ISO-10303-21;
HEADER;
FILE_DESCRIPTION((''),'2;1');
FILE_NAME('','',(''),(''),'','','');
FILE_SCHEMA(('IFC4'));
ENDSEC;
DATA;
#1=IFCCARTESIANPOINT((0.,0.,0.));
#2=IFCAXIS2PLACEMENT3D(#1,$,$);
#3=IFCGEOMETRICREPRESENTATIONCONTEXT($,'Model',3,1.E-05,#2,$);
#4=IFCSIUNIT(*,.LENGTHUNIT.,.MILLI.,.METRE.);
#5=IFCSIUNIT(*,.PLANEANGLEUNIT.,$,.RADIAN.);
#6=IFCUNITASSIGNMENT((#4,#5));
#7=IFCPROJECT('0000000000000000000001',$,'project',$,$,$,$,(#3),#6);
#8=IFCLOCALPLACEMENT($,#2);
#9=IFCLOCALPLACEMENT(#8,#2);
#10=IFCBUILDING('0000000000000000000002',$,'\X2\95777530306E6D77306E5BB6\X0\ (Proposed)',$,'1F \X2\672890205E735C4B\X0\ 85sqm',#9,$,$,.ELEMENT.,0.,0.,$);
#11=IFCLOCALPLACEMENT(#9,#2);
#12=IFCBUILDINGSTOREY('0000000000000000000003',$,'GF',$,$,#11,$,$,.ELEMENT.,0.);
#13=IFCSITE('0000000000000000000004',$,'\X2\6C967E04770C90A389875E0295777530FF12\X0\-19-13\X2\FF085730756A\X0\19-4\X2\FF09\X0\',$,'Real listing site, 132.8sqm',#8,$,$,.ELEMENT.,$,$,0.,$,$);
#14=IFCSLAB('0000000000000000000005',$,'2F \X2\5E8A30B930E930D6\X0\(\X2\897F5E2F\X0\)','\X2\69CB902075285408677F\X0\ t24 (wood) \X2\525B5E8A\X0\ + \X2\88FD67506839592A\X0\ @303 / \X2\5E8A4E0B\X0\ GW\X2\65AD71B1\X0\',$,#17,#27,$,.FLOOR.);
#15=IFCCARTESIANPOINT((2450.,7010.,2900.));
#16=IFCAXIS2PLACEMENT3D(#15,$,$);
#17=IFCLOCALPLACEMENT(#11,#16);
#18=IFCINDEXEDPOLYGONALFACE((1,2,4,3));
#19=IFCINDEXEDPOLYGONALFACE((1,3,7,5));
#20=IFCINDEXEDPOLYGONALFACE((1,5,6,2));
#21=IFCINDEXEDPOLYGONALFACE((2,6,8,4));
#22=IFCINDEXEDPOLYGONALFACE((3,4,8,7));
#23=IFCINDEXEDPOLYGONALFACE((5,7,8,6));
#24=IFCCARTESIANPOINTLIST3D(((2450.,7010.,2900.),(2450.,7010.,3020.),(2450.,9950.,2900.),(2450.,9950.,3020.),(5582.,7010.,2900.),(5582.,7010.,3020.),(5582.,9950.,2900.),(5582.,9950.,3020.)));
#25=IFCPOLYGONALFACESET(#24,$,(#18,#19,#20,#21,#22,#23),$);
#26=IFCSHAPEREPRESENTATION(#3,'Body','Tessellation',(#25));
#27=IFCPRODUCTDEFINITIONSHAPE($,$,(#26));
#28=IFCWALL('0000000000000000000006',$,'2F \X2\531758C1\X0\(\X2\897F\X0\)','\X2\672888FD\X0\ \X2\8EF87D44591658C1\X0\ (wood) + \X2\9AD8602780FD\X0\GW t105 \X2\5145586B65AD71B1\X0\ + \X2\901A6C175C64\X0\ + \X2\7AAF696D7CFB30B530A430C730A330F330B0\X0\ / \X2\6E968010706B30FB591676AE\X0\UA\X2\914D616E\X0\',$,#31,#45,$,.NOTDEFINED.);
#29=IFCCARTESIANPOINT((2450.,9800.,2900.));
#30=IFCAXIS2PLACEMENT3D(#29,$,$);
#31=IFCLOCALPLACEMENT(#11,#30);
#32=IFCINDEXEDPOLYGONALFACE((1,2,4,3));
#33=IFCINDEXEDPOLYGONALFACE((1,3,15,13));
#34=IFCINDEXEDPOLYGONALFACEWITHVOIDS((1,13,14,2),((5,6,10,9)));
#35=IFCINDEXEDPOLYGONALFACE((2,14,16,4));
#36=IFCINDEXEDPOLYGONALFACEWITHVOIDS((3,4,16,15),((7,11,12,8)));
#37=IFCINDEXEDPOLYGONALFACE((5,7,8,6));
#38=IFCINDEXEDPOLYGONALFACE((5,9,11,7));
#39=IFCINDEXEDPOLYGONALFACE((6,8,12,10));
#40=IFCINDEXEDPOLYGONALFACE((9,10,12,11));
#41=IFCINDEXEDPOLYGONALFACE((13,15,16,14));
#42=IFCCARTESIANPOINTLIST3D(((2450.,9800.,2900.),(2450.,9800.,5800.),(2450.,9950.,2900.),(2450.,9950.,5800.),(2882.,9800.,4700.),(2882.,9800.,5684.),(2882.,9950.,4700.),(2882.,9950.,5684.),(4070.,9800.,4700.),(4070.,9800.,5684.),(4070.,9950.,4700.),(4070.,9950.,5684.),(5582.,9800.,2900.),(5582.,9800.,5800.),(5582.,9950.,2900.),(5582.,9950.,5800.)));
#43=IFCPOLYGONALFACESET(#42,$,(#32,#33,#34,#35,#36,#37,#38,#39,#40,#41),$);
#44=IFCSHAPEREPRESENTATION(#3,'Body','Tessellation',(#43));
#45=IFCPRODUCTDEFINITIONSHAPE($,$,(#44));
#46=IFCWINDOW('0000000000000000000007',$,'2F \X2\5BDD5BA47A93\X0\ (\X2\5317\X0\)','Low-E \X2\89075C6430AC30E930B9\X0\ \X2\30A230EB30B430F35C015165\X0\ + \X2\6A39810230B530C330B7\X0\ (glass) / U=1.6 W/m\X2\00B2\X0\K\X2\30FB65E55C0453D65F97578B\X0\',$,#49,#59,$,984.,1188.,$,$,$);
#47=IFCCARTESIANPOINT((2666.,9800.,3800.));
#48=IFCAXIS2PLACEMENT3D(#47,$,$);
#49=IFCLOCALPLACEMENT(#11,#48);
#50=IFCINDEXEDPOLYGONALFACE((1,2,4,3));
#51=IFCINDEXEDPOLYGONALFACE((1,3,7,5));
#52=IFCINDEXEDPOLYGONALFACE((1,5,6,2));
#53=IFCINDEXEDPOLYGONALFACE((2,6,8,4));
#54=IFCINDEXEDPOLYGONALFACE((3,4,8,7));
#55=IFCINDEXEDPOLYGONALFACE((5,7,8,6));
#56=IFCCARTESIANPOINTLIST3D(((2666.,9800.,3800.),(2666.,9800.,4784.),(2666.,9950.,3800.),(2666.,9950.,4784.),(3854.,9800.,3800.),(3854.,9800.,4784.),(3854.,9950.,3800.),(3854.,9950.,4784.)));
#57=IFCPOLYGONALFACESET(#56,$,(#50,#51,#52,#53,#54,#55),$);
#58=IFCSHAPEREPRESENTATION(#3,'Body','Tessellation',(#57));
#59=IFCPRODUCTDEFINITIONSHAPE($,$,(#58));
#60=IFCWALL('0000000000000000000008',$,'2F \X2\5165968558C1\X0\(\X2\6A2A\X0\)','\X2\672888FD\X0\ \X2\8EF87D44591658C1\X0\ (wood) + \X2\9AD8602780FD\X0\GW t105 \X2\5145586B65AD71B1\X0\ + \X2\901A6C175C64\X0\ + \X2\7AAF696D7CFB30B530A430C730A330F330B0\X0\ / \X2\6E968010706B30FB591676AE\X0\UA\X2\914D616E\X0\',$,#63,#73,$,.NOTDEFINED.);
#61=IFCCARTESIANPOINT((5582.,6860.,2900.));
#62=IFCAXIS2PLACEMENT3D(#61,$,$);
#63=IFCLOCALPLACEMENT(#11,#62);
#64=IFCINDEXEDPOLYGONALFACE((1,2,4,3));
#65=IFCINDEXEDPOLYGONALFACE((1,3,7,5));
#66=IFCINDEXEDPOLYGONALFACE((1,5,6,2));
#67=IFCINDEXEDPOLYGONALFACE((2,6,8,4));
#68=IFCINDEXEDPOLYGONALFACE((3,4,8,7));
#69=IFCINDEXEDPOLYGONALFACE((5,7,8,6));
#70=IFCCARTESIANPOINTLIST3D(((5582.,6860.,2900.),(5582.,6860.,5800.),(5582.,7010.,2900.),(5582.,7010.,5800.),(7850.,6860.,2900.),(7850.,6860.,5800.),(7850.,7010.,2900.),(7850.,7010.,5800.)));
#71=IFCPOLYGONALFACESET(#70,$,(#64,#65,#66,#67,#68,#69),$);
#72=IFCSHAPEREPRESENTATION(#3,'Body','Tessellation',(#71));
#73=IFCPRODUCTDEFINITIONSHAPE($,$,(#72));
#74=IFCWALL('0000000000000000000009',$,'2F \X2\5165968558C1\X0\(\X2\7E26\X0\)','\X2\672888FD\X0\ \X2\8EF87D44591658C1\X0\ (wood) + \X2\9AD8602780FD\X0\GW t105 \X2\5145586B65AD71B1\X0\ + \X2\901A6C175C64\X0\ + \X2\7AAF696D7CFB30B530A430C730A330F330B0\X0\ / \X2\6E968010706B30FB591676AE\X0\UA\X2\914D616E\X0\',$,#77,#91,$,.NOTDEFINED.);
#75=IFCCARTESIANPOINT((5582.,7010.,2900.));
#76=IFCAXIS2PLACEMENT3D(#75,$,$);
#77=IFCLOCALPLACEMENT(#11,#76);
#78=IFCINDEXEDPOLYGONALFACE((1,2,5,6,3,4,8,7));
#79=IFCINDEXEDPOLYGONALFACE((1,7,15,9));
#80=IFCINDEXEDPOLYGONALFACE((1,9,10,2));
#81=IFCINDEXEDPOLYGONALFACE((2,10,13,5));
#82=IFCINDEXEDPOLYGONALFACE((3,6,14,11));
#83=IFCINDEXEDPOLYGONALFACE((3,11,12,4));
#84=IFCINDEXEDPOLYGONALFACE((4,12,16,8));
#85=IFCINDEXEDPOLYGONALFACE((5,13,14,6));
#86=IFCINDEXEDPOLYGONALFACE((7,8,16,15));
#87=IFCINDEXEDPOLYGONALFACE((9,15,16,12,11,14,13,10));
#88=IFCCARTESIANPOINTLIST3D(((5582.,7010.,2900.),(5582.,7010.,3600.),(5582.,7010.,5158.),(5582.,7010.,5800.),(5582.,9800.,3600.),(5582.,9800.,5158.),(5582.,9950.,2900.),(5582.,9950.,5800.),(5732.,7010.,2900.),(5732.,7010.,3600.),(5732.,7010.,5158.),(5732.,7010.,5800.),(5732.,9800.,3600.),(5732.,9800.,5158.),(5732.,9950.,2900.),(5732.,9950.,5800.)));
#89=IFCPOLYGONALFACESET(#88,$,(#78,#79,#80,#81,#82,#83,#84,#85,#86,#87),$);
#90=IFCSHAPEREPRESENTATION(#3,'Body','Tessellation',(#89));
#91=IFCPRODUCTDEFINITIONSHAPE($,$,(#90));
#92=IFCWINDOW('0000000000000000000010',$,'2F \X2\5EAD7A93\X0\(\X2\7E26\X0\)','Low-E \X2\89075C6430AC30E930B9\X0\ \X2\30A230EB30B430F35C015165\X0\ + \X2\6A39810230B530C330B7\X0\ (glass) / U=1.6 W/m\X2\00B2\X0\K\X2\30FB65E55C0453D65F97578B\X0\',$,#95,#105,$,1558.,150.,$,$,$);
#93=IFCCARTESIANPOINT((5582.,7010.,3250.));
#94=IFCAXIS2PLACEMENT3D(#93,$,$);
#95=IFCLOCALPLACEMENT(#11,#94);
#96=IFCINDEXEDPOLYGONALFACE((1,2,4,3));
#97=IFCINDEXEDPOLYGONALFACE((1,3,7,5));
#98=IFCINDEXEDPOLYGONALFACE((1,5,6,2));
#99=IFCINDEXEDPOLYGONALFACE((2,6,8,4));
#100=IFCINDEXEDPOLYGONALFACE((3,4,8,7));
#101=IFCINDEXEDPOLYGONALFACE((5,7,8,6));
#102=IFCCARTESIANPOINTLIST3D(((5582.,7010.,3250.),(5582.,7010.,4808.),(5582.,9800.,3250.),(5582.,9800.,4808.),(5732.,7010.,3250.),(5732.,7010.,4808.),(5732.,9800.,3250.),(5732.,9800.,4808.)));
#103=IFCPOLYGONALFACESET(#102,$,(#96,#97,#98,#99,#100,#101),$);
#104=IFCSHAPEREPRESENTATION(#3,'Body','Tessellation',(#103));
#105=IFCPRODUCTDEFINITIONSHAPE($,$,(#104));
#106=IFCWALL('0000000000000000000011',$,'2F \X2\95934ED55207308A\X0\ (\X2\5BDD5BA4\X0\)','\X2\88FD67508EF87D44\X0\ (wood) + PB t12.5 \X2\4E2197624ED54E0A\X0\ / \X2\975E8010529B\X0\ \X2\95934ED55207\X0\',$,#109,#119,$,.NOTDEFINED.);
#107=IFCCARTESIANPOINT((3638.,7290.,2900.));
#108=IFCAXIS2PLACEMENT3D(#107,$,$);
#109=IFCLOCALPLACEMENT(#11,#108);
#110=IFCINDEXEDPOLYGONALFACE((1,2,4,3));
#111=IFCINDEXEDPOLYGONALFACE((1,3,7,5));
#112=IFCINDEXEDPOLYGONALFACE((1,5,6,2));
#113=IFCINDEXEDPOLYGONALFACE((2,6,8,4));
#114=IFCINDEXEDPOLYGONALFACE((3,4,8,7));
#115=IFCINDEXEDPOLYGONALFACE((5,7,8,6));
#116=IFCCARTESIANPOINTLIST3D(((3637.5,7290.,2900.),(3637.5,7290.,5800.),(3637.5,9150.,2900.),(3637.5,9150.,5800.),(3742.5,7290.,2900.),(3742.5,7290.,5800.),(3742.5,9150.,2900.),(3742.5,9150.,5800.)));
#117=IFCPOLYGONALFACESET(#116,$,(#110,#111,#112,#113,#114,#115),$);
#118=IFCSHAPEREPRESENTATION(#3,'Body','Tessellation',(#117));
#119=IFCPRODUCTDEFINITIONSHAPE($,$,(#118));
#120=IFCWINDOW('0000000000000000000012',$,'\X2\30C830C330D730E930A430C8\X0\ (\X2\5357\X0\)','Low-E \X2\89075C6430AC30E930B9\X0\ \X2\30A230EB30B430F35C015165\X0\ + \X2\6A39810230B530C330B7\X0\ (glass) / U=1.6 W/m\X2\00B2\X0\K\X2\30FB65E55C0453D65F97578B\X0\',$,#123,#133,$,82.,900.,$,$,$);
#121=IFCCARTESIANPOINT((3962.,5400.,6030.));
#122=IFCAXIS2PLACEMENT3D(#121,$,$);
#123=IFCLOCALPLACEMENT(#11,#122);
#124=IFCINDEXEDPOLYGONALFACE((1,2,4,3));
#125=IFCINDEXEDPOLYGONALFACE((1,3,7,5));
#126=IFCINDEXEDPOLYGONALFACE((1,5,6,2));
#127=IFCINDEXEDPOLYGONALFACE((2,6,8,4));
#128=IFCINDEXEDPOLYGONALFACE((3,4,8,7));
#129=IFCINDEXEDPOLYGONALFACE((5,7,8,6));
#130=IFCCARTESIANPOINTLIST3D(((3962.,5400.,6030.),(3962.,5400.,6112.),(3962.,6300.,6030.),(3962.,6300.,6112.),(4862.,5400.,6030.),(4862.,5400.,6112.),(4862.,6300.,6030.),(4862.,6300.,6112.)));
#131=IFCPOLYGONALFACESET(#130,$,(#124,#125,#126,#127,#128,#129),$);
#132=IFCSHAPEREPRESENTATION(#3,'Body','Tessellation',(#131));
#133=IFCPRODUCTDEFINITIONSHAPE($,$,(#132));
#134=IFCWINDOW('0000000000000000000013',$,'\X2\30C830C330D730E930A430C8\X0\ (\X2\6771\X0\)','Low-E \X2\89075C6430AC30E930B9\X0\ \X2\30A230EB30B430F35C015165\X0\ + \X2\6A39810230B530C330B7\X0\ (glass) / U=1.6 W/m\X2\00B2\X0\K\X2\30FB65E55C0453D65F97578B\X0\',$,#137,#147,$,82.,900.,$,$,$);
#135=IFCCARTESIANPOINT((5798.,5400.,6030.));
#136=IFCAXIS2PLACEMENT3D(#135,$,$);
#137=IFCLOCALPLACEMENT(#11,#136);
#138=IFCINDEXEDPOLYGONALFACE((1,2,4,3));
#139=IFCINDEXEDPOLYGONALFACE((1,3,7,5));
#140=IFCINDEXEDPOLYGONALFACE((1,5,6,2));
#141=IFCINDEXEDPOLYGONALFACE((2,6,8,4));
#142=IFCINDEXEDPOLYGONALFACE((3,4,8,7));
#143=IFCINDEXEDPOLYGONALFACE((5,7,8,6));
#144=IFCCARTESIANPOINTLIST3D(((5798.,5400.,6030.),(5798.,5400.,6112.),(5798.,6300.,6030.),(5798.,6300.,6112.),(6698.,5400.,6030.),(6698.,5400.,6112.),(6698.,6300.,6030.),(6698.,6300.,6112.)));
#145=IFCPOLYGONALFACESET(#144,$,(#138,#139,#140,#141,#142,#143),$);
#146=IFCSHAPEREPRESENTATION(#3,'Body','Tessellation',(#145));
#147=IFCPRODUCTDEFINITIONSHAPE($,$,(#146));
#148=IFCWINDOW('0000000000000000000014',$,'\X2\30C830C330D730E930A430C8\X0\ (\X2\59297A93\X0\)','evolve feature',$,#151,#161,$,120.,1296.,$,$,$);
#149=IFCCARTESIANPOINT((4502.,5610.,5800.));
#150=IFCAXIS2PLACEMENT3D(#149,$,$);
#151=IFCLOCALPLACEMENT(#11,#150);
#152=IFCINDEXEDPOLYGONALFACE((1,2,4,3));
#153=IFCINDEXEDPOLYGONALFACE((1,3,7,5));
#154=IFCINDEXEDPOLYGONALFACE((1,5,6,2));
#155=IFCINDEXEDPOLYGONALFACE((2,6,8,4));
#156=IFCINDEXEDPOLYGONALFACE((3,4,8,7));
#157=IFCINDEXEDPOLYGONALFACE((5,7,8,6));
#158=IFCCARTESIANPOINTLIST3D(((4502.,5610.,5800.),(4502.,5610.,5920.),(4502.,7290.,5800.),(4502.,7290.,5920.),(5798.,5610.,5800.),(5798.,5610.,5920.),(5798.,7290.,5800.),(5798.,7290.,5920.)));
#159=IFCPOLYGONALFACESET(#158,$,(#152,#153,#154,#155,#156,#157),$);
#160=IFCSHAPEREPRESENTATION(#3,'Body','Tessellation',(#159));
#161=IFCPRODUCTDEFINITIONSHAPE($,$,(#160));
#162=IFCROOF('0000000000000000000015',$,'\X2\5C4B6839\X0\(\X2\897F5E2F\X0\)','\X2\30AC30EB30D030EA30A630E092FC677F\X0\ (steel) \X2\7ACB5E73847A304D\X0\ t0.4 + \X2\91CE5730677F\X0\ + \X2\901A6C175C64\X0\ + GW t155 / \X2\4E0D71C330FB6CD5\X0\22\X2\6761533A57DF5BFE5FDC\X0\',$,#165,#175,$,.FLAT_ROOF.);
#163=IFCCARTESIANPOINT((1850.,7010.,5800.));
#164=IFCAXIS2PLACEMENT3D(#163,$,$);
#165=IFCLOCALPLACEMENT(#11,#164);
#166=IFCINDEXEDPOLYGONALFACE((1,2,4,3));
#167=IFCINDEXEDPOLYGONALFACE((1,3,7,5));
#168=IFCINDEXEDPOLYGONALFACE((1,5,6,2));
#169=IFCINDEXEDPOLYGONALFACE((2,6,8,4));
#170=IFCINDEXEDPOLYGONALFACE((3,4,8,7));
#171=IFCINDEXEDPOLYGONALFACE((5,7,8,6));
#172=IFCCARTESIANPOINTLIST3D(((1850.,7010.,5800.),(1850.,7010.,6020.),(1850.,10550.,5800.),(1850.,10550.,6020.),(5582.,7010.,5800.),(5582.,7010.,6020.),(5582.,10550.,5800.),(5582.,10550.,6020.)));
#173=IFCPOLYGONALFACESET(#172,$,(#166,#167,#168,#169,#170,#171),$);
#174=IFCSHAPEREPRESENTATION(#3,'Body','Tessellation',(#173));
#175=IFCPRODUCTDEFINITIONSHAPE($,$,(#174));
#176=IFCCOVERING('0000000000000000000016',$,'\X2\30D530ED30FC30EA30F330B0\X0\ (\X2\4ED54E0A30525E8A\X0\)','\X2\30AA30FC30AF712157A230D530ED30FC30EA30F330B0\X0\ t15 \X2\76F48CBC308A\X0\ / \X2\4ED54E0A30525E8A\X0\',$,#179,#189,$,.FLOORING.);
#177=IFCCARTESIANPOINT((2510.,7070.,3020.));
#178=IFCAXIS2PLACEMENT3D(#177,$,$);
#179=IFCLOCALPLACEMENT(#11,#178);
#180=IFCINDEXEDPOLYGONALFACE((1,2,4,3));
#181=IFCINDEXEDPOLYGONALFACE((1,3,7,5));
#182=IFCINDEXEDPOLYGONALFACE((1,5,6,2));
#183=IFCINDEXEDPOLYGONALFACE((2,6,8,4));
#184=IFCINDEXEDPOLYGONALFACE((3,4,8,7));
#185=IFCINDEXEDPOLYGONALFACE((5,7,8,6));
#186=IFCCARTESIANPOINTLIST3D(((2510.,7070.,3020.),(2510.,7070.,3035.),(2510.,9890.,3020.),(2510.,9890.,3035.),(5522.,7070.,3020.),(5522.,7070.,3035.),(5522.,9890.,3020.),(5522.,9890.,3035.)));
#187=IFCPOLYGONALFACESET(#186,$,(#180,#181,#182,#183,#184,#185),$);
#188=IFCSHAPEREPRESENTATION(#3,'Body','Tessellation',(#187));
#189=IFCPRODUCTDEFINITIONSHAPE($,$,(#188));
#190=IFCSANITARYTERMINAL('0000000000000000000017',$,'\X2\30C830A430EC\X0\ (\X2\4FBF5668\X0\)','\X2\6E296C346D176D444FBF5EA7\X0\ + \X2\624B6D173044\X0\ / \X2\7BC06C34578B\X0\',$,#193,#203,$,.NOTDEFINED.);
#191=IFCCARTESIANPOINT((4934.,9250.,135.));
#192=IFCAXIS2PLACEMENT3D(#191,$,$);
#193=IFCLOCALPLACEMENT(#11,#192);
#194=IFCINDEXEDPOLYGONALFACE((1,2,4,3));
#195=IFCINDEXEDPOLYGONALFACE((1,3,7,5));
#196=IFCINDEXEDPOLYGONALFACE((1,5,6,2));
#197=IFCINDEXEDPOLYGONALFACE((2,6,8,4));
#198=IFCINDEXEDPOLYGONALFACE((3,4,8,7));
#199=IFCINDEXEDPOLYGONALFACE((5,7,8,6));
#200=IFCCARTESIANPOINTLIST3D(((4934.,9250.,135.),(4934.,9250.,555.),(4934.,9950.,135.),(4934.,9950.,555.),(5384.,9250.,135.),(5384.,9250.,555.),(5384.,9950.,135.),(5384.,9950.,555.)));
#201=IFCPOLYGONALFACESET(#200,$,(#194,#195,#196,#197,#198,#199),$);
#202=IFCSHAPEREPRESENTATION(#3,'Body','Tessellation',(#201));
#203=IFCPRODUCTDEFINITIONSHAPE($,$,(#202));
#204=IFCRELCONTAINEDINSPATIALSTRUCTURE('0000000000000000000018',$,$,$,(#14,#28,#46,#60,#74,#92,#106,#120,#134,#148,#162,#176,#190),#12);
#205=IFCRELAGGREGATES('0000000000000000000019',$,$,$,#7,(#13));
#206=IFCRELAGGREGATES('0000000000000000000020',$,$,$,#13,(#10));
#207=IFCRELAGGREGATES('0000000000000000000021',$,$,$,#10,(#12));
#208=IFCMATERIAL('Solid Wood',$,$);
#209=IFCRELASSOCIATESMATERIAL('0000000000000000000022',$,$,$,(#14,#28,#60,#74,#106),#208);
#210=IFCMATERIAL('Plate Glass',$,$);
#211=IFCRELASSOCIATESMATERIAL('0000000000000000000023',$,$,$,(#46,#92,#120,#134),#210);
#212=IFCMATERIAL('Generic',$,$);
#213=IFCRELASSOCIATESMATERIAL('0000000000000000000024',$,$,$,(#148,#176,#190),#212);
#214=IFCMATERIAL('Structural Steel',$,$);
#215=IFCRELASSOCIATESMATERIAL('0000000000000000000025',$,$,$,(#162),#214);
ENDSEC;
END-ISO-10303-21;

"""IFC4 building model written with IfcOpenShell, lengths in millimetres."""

from ifc_helpers import new_model, si_unit, frame, frame_2d, origin, place, context, project, spatial, rectangle, extrude, material, element, fill, save


model = new_model("IFC4")

# Units and contexts
model_context = context("Model", 3, precision=1e-05, world=origin())
ifc_project = project(units=[si_unit("LENGTHUNIT", "METRE", prefix="MILLI"), si_unit("PLANEANGLEUNIT", "RADIAN")], contexts=[model_context])

# Site, building, storey
site_placement = place(None, origin())
site = spatial("IfcSite", under=ifc_project, at=site_placement, Name="沖縄県那覇市長田２-19-13（地番19-4）", ObjectType="Real listing site, 132.8sqm", CompositionType="ELEMENT", RefElevation=0.0)
building_placement = place(site_placement, origin())
building = spatial("IfcBuilding", under=site, at=building_placement, Name="長田の海の家 (Proposed)", ObjectType="1F 木造平屋 85sqm", CompositionType="ELEMENT", ElevationOfRefHeight=0.0, ElevationOfTerrain=0.0)
storey_placement = place(building_placement, origin())
storey = spatial("IfcBuildingStorey", under=building, at=storey_placement, Name="GF", CompositionType="ELEMENT", Elevation=0.0)

# Slab
ifc_material_1 = material(Name="Solid Wood")
slab_placement = place(storey_placement, frame((2450.0, 7010.0, 2900.0)))
element("IfcSlab", 1, at=slab_placement, inside=storey, material=ifc_material_1, Name="2F 床スラブ(西帯)", Description="構造用合板 t24 (wood) 剛床 + 製材根太 @303 / 床下 GW断熱", PredefinedType="FLOOR", context=model_context, shape_type="SweptSolid", body=[
    extrude(rectangle(XDim=3132.0, YDim=2940.0, at=frame_2d((1566.0, 1470.0))), frame((2450.0, 7010.0, 2900.0)), (0.0, 0.0, 1.0), 120.0),
])

# Wall, opening, window
wall_1_placement = place(storey_placement, frame((2450.0, 9800.0, 2900.0)))
wall_1 = element("IfcWall", 2, at=wall_1_placement, inside=storey, material=ifc_material_1, Name="2F 北壁(西)", Description="木製 軸組外壁 (wood) + 高性能GW t105 充填断熱 + 通気層 + 窯業系サイディング / 準耐火・外皮UA配慮", PredefinedType="NOTDEFINED", context=model_context, shape_type="SweptSolid", body=[
    extrude(rectangle(XDim=3132.0, YDim=150.0, at=frame_2d((1566.0, 75.0))), frame((2450.0, 9800.0, 2900.0)), (0.0, 0.0, 1.0), 2900.0),
])
opening_1_placement = place(storey_placement, frame((2666.0, 9800.0, 3800.0)))
opening_1 = element("IfcOpeningElement", 3, at=opening_1_placement, cuts=wall_1, PredefinedType="NOTDEFINED", context=model_context, shape_type="SweptSolid", body=[
    extrude(rectangle(XDim=1188.0, YDim=150.0, at=frame_2d((594.0, 75.0))), frame((2666.0, 9800.0, 3800.0)), (0.0, 0.0, 1.0), 984.0),
])
ifc_material_2 = material(Name="Plate Glass")
window_1_placement = place(storey_placement, frame((2666.0, 9800.0, 3800.0)))
window_1 = element("IfcWindow", 4, at=window_1_placement, inside=storey, material=ifc_material_2, Name="2F 寝室窓 (北)", Description="Low-E 複層ガラス アルゴン封入 + 樹脂サッシ (glass) / U=1.6 W/m²K・日射取得型", OverallHeight=984.0, OverallWidth=1188.0, context=model_context, shape_type="SweptSolid", body=[
    extrude(rectangle(XDim=1188.0, YDim=150.0, at=frame_2d((594.0, 75.0))), frame((2666.0, 9800.0, 3800.0)), (0.0, 0.0, 1.0), 984.0),
])
fill(opening_1, window_1)

# Wall
wall_2_placement = place(storey_placement, frame((5582.0, 6860.0, 2900.0)))
element("IfcWall", 5, at=wall_2_placement, inside=storey, material=ifc_material_1, Name="2F 入隅壁(横)", Description="木製 軸組外壁 (wood) + 高性能GW t105 充填断熱 + 通気層 + 窯業系サイディング / 準耐火・外皮UA配慮", PredefinedType="NOTDEFINED", context=model_context, shape_type="SweptSolid", body=[
    extrude(rectangle(XDim=2268.0, YDim=150.0, at=frame_2d((1134.0, 75.0))), frame((5582.0, 6860.0, 2900.0)), (0.0, 0.0, 1.0), 2900.0),
])

# Wall, opening, window
wall_3_placement = place(storey_placement, frame((5582.0, 7010.0, 2900.0)))
wall_3 = element("IfcWall", 6, at=wall_3_placement, inside=storey, material=ifc_material_1, Name="2F 入隅壁(縦)", Description="木製 軸組外壁 (wood) + 高性能GW t105 充填断熱 + 通気層 + 窯業系サイディング / 準耐火・外皮UA配慮", PredefinedType="NOTDEFINED", context=model_context, shape_type="SweptSolid", body=[
    extrude(rectangle(XDim=150.0, YDim=2940.0, at=frame_2d((75.0, 1470.0))), frame((5582.0, 7010.0, 2900.0)), (0.0, 0.0, 1.0), 2900.0),
])
opening_2_placement = place(storey_placement, frame((5582.0, 7010.0, 3250.0)))
opening_2 = element("IfcOpeningElement", 7, at=opening_2_placement, cuts=wall_3, PredefinedType="NOTDEFINED", context=model_context, shape_type="SweptSolid", body=[
    extrude(rectangle(XDim=150.0, YDim=2790.0, at=frame_2d((75.0, 1395.0))), frame((5582.0, 7010.0, 3250.0)), (0.0, 0.0, 1.0), 1558.0),
])
window_2_placement = place(storey_placement, frame((5582.0, 7010.0, 3250.0)))
window_2 = element("IfcWindow", 8, at=window_2_placement, inside=storey, material=ifc_material_2, Name="2F 庭窓(縦)", Description="Low-E 複層ガラス アルゴン封入 + 樹脂サッシ (glass) / U=1.6 W/m²K・日射取得型", OverallHeight=1558.0, OverallWidth=150.0, context=model_context, shape_type="SweptSolid", body=[
    extrude(rectangle(XDim=150.0, YDim=2790.0, at=frame_2d((75.0, 1395.0))), frame((5582.0, 7010.0, 3250.0)), (0.0, 0.0, 1.0), 1558.0),
])
fill(opening_2, window_2)

# Wall
wall_4_placement = place(storey_placement, frame((3638.0, 7290.0, 2900.0)))
element("IfcWall", 9, at=wall_4_placement, inside=storey, material=ifc_material_1, Name="2F 間仕切り (寝室)", Description="製材軸組 (wood) + PB t12.5 両面仕上 / 非耐力 間仕切", PredefinedType="NOTDEFINED", context=model_context, shape_type="SweptSolid", body=[
    extrude(rectangle(XDim=105.0, YDim=1860.0, at=frame_2d((52.0, 930.0))), frame((3638.0, 7290.0, 2900.0)), (0.0, 0.0, 1.0), 2900.0),
])

# Windows
window_3_placement = place(storey_placement, frame((3962.0, 5400.0, 6030.0)))
element("IfcWindow", 10, at=window_3_placement, inside=storey, material=ifc_material_2, Name="トップライト (南)", Description="Low-E 複層ガラス アルゴン封入 + 樹脂サッシ (glass) / U=1.6 W/m²K・日射取得型", OverallHeight=82.0, OverallWidth=900.0, context=model_context, shape_type="SweptSolid", body=[
    extrude(rectangle(XDim=900.0, YDim=900.0, at=frame_2d((450.0, 450.0))), frame((3962.0, 5400.0, 6030.0)), (0.0, 0.0, 1.0), 82.0),
])
window_4_placement = place(storey_placement, frame((5798.0, 5400.0, 6030.0)))
element("IfcWindow", 11, at=window_4_placement, inside=storey, material=ifc_material_2, Name="トップライト (東)", Description="Low-E 複層ガラス アルゴン封入 + 樹脂サッシ (glass) / U=1.6 W/m²K・日射取得型", OverallHeight=82.0, OverallWidth=900.0, context=model_context, shape_type="SweptSolid", body=[
    extrude(rectangle(XDim=900.0, YDim=900.0, at=frame_2d((450.0, 450.0))), frame((5798.0, 5400.0, 6030.0)), (0.0, 0.0, 1.0), 82.0),
])
ifc_material_3 = material(Name="Generic")
window_5_placement = place(storey_placement, frame((4502.0, 5610.0, 5800.0)))
element("IfcWindow", 12, at=window_5_placement, inside=storey, material=ifc_material_3, Name="トップライト (天窓)", Description="evolve feature", OverallHeight=120.0, OverallWidth=1296.0, context=model_context, shape_type="SweptSolid", body=[
    extrude(rectangle(XDim=1296.0, YDim=1680.0, at=frame_2d((648.0, 840.0))), frame((4502.0, 5610.0, 5800.0)), (0.0, 0.0, 1.0), 120.0),
])

# Roof
ifc_material_4 = material(Name="Structural Steel")
for number, where, name in (
    (13, (1850.0, 7010.0, 5800.0), "屋根(西帯)"),
):
    element("IfcRoof", number, at=place(storey_placement, frame(where)), inside=storey, material=ifc_material_4, Name=name, Description="ガルバリウム鋼板 (steel) 立平葺き t0.4 + 野地板 + 通気層 + GW t155 / 不燃・法22条区域対応", PredefinedType="FLAT_ROOF", context=model_context, shape_type="SweptSolid", body=[
        extrude(rectangle(XDim=3732.0, YDim=3540.0, at=frame_2d((1866.0, 1770.0))), frame((1850.0, 7010.0, 5800.0)), (0.0, 0.0, 1.0), 220.0),
    ])

# Covering
covering_placement = place(storey_placement, frame((2510.0, 7070.0, 3020.0)))
element("IfcCovering", 14, at=covering_placement, inside=storey, material=ifc_material_3, Name="フローリング (仕上げ床)", Description="オーク無垢フローリング t15 直貼り / 仕上げ床", PredefinedType="FLOORING", context=model_context, shape_type="SweptSolid", body=[
    extrude(rectangle(XDim=3012.0, YDim=2820.0, at=frame_2d((1506.0, 1410.0))), frame((2510.0, 7070.0, 3020.0)), (0.0, 0.0, 1.0), 15.0),
])

# Sanitary terminal
sanitary_terminal_placement = place(storey_placement, frame((4934.0, 9250.0, 135.0)))
element("IfcSanitaryTerminal", 15, at=sanitary_terminal_placement, inside=storey, material=ifc_material_3, Name="トイレ (便器)", Description="温水洗浄便座 + 手洗い / 節水型", PredefinedType="NOTDEFINED", context=model_context, shape_type="SweptSolid", body=[
    extrude(rectangle(XDim=450.0, YDim=700.0, at=frame_2d((225.0, 350.0))), frame((4934.0, 9250.0, 135.0)), (0.0, 0.0, 1.0), 420.0),
])

save(model, "model.ifc")
